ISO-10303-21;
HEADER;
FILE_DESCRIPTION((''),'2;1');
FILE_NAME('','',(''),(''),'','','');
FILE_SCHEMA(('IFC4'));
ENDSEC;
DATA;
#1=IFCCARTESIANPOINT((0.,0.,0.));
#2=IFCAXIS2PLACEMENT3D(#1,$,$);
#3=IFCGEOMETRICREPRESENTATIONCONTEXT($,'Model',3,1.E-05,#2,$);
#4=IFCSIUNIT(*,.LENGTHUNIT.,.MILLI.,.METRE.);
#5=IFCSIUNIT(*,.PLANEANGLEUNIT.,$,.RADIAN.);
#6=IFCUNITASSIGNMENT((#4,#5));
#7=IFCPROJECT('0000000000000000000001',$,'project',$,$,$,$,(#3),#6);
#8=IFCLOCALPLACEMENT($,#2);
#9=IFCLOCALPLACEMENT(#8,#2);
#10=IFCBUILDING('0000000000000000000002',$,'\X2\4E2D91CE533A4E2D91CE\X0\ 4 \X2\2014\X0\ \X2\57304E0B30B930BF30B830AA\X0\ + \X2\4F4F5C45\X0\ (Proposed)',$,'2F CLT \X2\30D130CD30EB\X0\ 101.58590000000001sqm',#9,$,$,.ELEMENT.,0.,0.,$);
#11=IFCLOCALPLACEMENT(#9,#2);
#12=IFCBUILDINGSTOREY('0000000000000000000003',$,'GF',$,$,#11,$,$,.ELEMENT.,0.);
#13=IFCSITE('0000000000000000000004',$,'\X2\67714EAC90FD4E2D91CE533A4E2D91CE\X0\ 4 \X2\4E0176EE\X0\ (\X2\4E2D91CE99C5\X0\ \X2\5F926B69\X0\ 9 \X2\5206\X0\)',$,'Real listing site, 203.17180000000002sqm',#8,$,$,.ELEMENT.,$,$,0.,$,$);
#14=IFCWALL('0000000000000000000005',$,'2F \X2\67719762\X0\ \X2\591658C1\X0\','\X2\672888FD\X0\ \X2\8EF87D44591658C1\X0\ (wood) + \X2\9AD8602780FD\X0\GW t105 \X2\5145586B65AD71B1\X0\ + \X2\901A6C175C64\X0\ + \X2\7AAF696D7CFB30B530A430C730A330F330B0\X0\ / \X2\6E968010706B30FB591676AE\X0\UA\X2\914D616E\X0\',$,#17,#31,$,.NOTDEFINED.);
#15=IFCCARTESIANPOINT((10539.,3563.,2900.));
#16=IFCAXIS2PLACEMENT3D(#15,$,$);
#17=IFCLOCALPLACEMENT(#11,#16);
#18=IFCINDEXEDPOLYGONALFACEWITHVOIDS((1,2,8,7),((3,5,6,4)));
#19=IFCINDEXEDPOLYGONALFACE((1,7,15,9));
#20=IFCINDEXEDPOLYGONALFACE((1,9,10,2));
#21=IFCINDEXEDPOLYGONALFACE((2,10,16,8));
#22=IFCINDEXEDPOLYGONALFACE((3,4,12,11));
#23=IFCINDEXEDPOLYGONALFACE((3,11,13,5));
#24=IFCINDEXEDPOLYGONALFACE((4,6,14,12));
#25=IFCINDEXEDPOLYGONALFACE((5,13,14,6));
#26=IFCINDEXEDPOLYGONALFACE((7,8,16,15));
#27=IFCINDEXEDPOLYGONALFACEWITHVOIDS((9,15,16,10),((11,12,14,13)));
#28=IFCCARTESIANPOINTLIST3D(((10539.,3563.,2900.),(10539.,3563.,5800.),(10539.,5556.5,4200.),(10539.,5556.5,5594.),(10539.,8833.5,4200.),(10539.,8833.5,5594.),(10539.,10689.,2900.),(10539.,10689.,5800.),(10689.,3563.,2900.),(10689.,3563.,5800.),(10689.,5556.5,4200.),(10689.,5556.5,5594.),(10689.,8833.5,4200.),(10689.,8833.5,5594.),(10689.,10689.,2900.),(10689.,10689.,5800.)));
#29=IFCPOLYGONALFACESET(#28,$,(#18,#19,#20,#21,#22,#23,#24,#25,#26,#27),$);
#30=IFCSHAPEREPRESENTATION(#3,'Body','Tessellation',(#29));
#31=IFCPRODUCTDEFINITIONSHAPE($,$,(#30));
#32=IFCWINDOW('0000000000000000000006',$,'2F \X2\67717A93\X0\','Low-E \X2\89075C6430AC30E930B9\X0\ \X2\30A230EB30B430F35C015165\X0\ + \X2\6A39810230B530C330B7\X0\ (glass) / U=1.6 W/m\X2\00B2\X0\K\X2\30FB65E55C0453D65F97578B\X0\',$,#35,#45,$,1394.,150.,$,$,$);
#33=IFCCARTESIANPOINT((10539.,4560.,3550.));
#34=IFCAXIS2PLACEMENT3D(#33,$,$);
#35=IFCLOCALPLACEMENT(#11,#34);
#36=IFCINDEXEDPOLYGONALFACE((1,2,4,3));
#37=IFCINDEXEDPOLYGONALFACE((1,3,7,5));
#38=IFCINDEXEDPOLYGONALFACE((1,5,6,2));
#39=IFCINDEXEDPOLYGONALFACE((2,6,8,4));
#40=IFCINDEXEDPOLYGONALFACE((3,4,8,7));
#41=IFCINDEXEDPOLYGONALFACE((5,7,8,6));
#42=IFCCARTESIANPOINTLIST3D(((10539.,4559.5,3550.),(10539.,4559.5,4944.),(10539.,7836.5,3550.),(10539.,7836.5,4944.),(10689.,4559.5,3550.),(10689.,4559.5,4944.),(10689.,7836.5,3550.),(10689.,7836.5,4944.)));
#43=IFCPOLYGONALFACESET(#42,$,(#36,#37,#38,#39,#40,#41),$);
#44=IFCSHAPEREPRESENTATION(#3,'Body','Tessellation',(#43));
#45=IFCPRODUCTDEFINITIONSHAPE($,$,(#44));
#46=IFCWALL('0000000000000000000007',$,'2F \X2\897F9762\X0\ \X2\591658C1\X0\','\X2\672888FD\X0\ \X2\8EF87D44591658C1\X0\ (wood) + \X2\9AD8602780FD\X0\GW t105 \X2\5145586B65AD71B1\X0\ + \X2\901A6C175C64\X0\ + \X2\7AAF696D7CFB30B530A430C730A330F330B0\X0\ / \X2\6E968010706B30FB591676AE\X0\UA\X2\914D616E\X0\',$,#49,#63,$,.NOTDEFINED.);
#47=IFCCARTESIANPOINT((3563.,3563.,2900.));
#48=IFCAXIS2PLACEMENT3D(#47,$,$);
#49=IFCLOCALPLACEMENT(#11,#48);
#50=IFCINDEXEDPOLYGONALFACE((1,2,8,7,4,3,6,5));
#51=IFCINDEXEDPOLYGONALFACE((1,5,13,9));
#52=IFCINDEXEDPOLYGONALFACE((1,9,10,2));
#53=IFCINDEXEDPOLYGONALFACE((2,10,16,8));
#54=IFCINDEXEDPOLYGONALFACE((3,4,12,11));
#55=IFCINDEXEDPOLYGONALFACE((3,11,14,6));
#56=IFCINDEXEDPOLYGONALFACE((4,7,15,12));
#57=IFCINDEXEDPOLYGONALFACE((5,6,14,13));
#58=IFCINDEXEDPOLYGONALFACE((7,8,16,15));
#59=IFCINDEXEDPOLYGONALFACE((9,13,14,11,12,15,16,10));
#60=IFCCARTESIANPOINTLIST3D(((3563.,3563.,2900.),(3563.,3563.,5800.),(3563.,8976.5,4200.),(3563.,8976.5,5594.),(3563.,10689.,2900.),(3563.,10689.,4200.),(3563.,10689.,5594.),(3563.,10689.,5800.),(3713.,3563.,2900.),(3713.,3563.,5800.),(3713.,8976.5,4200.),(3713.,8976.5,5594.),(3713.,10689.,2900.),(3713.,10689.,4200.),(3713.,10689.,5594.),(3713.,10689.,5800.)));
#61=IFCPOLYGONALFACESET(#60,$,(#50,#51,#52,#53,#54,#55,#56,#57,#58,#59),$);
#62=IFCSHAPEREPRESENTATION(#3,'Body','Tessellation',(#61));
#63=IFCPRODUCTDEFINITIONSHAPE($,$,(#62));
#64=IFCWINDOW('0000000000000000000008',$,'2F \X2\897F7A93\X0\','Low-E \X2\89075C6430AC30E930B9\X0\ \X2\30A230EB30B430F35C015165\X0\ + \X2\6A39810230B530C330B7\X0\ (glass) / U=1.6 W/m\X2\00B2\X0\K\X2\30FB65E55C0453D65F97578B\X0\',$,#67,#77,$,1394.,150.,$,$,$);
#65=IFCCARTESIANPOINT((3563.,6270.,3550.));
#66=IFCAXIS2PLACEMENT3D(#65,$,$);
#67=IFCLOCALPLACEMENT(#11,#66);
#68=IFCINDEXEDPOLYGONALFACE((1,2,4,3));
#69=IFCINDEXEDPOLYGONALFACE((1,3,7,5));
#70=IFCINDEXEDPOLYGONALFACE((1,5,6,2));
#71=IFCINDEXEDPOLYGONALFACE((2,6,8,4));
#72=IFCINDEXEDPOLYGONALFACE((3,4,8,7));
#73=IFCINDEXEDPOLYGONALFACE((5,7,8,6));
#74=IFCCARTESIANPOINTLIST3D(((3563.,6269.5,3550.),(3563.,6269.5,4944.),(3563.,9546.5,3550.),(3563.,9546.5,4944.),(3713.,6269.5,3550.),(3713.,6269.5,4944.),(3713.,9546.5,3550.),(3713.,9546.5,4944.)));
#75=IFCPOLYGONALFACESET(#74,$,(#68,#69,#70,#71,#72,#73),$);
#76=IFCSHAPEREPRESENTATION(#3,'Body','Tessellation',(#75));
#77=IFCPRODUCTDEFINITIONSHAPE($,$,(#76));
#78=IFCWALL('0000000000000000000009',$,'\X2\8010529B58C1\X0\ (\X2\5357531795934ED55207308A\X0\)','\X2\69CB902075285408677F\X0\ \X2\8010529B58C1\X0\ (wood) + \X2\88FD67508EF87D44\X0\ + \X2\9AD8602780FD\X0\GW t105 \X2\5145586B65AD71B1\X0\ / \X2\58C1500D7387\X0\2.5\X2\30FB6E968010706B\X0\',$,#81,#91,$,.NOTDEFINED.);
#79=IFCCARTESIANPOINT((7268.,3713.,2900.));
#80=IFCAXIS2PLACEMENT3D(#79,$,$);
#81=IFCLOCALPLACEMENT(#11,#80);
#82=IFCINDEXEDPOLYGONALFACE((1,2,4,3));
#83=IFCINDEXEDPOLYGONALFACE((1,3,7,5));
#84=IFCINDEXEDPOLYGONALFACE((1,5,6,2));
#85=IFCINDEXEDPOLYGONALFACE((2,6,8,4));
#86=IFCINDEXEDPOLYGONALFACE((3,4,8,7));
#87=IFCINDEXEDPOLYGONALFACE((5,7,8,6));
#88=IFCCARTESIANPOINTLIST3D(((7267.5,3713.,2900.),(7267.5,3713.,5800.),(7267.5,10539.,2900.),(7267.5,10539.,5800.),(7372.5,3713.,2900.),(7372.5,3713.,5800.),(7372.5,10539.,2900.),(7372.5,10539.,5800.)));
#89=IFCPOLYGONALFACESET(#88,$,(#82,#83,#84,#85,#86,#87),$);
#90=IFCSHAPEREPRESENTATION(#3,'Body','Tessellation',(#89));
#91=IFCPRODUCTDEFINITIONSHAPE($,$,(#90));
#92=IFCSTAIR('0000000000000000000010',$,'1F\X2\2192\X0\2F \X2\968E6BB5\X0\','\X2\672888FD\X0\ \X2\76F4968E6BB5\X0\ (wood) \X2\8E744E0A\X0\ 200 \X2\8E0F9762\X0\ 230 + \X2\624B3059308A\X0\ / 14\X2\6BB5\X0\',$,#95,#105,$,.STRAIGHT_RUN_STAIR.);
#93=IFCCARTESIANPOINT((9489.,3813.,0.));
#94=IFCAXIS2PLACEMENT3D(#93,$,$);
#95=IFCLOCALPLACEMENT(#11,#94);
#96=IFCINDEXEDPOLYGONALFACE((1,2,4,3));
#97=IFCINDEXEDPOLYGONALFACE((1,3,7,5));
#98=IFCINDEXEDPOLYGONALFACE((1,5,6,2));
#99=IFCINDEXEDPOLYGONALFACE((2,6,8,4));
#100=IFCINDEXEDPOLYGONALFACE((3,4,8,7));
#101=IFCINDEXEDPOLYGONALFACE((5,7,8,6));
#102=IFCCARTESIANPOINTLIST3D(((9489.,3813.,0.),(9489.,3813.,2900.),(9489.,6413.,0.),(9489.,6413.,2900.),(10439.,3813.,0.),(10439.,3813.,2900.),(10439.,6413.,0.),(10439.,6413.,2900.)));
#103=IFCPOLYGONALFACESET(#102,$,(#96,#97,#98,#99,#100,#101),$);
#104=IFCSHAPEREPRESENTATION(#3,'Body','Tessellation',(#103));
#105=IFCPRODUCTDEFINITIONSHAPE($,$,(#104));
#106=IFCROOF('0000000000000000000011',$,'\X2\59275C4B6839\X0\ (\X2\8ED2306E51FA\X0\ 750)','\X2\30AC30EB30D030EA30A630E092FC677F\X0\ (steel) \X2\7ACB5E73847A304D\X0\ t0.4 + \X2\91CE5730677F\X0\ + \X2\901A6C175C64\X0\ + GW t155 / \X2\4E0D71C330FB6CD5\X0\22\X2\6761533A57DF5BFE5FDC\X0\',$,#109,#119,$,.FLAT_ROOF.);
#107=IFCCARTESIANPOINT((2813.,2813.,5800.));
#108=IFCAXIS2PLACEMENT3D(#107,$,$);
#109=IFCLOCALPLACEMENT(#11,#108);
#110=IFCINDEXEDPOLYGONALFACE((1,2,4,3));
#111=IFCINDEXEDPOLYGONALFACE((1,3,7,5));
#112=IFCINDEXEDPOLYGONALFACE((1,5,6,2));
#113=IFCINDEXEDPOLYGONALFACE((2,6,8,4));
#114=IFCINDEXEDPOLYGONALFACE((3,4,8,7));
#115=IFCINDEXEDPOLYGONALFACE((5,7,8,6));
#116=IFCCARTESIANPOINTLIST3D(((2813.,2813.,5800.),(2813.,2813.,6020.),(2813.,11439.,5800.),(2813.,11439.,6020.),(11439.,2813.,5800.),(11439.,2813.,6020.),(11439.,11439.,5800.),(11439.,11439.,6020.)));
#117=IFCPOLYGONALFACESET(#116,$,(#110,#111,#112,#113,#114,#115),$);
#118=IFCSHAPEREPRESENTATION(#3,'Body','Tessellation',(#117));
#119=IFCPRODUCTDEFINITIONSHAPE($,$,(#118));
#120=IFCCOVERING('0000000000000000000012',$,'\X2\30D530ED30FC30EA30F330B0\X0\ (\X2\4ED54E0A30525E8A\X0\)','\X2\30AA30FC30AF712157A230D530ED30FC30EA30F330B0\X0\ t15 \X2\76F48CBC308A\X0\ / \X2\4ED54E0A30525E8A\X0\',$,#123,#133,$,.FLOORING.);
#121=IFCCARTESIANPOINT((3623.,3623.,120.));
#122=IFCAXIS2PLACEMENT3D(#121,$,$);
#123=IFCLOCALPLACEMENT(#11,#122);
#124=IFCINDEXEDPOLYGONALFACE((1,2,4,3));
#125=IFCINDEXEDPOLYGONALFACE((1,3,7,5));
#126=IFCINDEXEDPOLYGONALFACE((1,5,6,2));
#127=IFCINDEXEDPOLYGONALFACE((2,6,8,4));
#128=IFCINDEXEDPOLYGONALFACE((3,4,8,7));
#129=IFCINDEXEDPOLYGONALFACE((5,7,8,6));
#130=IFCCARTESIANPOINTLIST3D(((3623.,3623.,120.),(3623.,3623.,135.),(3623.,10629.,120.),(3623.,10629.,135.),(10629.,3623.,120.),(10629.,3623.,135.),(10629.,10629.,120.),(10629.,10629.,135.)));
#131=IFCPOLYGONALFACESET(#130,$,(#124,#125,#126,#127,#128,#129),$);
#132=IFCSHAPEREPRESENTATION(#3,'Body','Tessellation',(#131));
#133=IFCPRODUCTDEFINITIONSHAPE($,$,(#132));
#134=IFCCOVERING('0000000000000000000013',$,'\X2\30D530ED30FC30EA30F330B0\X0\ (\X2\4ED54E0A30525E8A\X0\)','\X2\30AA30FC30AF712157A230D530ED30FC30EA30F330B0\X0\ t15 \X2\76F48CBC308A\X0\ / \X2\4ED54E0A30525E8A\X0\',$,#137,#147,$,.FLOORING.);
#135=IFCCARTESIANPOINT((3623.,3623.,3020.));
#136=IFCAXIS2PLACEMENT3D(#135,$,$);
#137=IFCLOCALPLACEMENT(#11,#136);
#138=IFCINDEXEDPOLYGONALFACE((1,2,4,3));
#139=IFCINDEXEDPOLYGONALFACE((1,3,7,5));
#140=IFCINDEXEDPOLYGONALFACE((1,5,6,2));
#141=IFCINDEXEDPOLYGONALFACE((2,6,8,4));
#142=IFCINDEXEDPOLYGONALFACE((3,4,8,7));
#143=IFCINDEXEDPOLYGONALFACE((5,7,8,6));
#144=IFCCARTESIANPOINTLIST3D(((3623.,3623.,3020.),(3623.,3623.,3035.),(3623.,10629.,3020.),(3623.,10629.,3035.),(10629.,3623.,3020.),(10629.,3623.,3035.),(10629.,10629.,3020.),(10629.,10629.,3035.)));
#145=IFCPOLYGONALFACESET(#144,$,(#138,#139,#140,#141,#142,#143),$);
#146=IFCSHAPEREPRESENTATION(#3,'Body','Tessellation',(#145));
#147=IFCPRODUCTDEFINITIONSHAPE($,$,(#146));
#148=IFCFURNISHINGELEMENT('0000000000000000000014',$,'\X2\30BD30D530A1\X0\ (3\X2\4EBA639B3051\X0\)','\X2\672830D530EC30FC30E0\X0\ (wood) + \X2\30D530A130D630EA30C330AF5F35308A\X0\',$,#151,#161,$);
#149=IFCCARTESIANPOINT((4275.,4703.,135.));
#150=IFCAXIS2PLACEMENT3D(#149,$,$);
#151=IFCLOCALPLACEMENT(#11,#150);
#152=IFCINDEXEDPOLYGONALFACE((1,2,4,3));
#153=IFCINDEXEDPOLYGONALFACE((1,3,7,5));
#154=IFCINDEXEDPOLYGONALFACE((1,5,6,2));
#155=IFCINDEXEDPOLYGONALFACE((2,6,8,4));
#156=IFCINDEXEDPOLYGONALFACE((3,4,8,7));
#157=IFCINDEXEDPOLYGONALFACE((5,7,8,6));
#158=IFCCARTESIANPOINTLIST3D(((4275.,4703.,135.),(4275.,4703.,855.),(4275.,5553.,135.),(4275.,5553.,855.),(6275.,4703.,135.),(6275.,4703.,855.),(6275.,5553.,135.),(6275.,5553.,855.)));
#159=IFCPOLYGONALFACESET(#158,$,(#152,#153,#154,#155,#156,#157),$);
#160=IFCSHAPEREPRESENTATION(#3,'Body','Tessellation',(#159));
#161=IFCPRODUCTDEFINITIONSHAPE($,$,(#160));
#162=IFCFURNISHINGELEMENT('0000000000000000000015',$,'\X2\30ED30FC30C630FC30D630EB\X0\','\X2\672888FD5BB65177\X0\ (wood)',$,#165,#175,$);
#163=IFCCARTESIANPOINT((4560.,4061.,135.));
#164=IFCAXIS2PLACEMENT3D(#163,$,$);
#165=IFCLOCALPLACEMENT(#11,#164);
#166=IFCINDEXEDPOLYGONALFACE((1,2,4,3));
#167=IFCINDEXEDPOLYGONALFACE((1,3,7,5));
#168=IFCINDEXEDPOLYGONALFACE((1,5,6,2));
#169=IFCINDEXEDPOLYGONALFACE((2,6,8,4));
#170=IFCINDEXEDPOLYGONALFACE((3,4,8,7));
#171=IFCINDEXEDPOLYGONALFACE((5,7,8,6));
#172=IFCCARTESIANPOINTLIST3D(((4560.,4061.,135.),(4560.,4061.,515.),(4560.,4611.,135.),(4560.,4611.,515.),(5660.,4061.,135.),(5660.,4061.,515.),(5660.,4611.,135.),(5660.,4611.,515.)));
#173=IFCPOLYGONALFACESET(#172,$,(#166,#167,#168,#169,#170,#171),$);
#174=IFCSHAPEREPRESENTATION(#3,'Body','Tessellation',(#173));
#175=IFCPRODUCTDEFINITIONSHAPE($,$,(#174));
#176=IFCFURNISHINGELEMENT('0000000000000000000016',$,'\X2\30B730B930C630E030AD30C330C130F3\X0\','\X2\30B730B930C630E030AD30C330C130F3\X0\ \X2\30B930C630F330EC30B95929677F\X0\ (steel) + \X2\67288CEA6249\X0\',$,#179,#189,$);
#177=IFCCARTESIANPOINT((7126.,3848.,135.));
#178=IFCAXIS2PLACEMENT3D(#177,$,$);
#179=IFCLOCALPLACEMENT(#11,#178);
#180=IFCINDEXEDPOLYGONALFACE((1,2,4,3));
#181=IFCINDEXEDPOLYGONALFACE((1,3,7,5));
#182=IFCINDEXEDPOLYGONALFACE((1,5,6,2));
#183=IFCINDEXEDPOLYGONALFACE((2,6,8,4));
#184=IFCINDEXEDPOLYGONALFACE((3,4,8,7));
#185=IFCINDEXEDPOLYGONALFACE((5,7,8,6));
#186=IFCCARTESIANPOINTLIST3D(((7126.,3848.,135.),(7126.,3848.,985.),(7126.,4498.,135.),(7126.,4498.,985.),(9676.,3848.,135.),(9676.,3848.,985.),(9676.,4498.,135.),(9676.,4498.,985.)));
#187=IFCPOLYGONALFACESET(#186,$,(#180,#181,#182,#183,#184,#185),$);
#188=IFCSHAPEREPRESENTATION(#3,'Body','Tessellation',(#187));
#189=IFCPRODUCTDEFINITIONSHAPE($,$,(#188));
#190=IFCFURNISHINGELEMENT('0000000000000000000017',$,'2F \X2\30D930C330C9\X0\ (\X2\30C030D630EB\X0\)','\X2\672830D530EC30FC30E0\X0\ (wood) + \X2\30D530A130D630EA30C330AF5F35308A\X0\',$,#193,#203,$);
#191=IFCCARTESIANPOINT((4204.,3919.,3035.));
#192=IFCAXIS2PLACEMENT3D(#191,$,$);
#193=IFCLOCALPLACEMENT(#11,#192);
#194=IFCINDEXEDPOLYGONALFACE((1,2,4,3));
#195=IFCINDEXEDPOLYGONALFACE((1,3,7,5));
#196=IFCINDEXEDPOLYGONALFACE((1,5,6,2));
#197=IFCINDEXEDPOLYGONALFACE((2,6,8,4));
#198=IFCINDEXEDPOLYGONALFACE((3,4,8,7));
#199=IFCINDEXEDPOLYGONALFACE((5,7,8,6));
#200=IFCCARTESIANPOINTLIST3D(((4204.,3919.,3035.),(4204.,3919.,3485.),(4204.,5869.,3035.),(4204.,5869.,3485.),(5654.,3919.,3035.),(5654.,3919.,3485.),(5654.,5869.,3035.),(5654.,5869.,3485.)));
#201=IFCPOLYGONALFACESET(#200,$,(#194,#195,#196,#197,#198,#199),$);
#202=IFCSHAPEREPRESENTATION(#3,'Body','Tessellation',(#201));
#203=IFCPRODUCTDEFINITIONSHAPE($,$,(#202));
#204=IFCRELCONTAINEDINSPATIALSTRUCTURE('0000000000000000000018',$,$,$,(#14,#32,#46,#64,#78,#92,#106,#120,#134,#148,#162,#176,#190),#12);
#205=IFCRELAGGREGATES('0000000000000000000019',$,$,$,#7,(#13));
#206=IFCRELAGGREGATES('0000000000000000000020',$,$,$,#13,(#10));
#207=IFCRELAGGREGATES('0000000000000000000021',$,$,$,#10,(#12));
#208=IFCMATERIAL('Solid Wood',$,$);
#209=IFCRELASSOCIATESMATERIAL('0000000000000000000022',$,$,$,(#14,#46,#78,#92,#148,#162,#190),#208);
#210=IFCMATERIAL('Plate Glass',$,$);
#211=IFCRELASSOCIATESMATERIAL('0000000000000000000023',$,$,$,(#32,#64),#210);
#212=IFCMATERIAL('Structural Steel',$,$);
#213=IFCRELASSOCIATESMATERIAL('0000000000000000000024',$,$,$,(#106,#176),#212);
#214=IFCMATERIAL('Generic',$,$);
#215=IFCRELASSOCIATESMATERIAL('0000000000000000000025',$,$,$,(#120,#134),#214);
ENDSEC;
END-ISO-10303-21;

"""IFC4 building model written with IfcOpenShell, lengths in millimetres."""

from ifc_helpers import new_model, si_unit, frame, frame_2d, origin, place, context, project, spatial, rectangle, extrude, material, element, fill, save


model = new_model("IFC4")

# Units and contexts
model_context = context("Model", 3, precision=1e-05, world=origin())
ifc_project = project(units=[si_unit("LENGTHUNIT", "METRE", prefix="MILLI"), si_unit("PLANEANGLEUNIT", "RADIAN")], contexts=[model_context])

# Site, building, storey
site_placement = place(None, origin())
site = spatial("IfcSite", under=ifc_project, at=site_placement, Name="東京都中野区中野 4 丁目 (中野駅 徒歩 9 分)", ObjectType="Real listing site, 203.17180000000002sqm", CompositionType="ELEMENT", RefElevation=0.0)
building_placement = place(site_placement, origin())
building = spatial("IfcBuilding", under=site, at=building_placement, Name="中野区中野 4 — 地下スタジオ + 住居 (Proposed)", ObjectType="2F CLT パネル 101.58590000000001sqm", CompositionType="ELEMENT", ElevationOfRefHeight=0.0, ElevationOfTerrain=0.0)
storey_placement = place(building_placement, origin())
storey = spatial("IfcBuildingStorey", under=building, at=storey_placement, Name="GF", CompositionType="ELEMENT", Elevation=0.0)

# Shared definitions
ifc_material_1 = material(Name="Solid Wood")

# Shared definitions
ifc_material_2 = material(Name="Plate Glass")

# Walls, openings, windows
wall_1_placement = place(storey_placement, frame((10539.0, 3563.0, 2900.0)))
wall_1 = element("IfcWall", 1, at=wall_1_placement, inside=storey, material=ifc_material_1, Name="2F 東面 外壁", Description="木製 軸組外壁 (wood) + 高性能GW t105 充填断熱 + 通気層 + 窯業系サイディング / 準耐火・外皮UA配慮", PredefinedType="NOTDEFINED", context=model_context, shape_type="SweptSolid", body=[
    extrude(rectangle(XDim=150.0, YDim=7126.0, at=frame_2d((75.0, 3563.0))), frame((10539.0, 3563.0, 2900.0)), (0.0, 0.0, 1.0), 2900.0),
])
opening_1_placement = place(storey_placement, frame((10539.0, 4560.0, 3550.0)))
opening_1 = element("IfcOpeningElement", 2, at=opening_1_placement, cuts=wall_1, PredefinedType="NOTDEFINED", context=model_context, shape_type="SweptSolid", body=[
    extrude(rectangle(XDim=150.0, YDim=3277.0, at=frame_2d((75.0, 1638.0))), frame((10539.0, 4560.0, 3550.0)), (0.0, 0.0, 1.0), 1394.0),
])
window_1_placement = place(storey_placement, frame((10539.0, 4560.0, 3550.0)))
window_1 = element("IfcWindow", 3, at=window_1_placement, inside=storey, material=ifc_material_2, Name="2F 東窓", Description="Low-E 複層ガラス アルゴン封入 + 樹脂サッシ (glass) / U=1.6 W/m²K・日射取得型", OverallHeight=1394.0, OverallWidth=150.0, context=model_context, shape_type="SweptSolid", body=[
    extrude(rectangle(XDim=150.0, YDim=3277.0, at=frame_2d((75.0, 1638.0))), frame((10539.0, 4560.0, 3550.0)), (0.0, 0.0, 1.0), 1394.0),
])
fill(opening_1, window_1)
wall_2_placement = place(storey_placement, frame((3563.0, 3563.0, 2900.0)))
wall_2 = element("IfcWall", 4, at=wall_2_placement, inside=storey, material=ifc_material_1, Name="2F 西面 外壁", Description="木製 軸組外壁 (wood) + 高性能GW t105 充填断熱 + 通気層 + 窯業系サイディング / 準耐火・外皮UA配慮", PredefinedType="NOTDEFINED", context=model_context, shape_type="SweptSolid", body=[
    extrude(rectangle(XDim=150.0, YDim=7126.0, at=frame_2d((75.0, 3563.0))), frame((3563.0, 3563.0, 2900.0)), (0.0, 0.0, 1.0), 2900.0),
])
opening_2_placement = place(storey_placement, frame((3563.0, 6270.0, 3550.0)))
opening_2 = element("IfcOpeningElement", 5, at=opening_2_placement, cuts=wall_2, PredefinedType="NOTDEFINED", context=model_context, shape_type="SweptSolid", body=[
    extrude(rectangle(XDim=150.0, YDim=3277.0, at=frame_2d((75.0, 1638.0))), frame((3563.0, 6270.0, 3550.0)), (0.0, 0.0, 1.0), 1394.0),
])
window_2_placement = place(storey_placement, frame((3563.0, 6270.0, 3550.0)))
window_2 = element("IfcWindow", 6, at=window_2_placement, inside=storey, material=ifc_material_2, Name="2F 西窓", Description="Low-E 複層ガラス アルゴン封入 + 樹脂サッシ (glass) / U=1.6 W/m²K・日射取得型", OverallHeight=1394.0, OverallWidth=150.0, context=model_context, shape_type="SweptSolid", body=[
    extrude(rectangle(XDim=150.0, YDim=3277.0, at=frame_2d((75.0, 1638.0))), frame((3563.0, 6270.0, 3550.0)), (0.0, 0.0, 1.0), 1394.0),
])
fill(opening_2, window_2)

# Wall
wall_3_placement = place(storey_placement, frame((7268.0, 3713.0, 2900.0)))
element("IfcWall", 7, at=wall_3_placement, inside=storey, material=ifc_material_1, Name="耐力壁 (南北間仕切り)", Description="構造用合板 耐力壁 (wood) + 製材軸組 + 高性能GW t105 充填断熱 / 壁倍率2.5・準耐火", PredefinedType="NOTDEFINED", context=model_context, shape_type="SweptSolid", body=[
    extrude(rectangle(XDim=105.0, YDim=6826.0, at=frame_2d((52.0, 3413.0))), frame((7268.0, 3713.0, 2900.0)), (0.0, 0.0, 1.0), 2900.0),
])

# Stair
stair_placement = place(storey_placement, frame((9489.0, 3813.0, 0.0)))
element("IfcStair", 8, at=stair_placement, inside=storey, material=ifc_material_1, Name="1F→2F 階段", Description="木製 直階段 (wood) 蹴上 200 踏面 230 + 手すり / 14段", PredefinedType="STRAIGHT_RUN_STAIR", context=model_context, shape_type="SweptSolid", body=[
    extrude(rectangle(XDim=950.0, YDim=2600.0, at=frame_2d((475.0, 1300.0))), frame((9489.0, 3813.0, 0.0)), (0.0, 0.0, 1.0), 2900.0),
])

# Roof
ifc_material_3 = material(Name="Structural Steel")
roof_placement = place(storey_placement, frame((2813.0, 2813.0, 5800.0)))
element("IfcRoof", 9, at=roof_placement, inside=storey, material=ifc_material_3, Name="大屋根 (軒の出 750)", Description="ガルバリウム鋼板 (steel) 立平葺き t0.4 + 野地板 + 通気層 + GW t155 / 不燃・法22条区域対応", PredefinedType="FLAT_ROOF", context=model_context, shape_type="SweptSolid", body=[
    extrude(rectangle(XDim=8626.0, YDim=8626.0, at=frame_2d((4313.0, 4313.0))), frame((2813.0, 2813.0, 5800.0)), (0.0, 0.0, 1.0), 220.0),
])

# Coverings
ifc_material_4 = material(Name="Generic")
covering_1_placement = place(storey_placement, frame((3623.0, 3623.0, 120.0)))
element("IfcCovering", 10, at=covering_1_placement, inside=storey, material=ifc_material_4, Name="フローリング (仕上げ床)", Description="オーク無垢フローリング t15 直貼り / 仕上げ床", PredefinedType="FLOORING", context=model_context, shape_type="SweptSolid", body=[
    extrude(rectangle(XDim=7006.0, YDim=7006.0, at=frame_2d((3503.0, 3503.0))), frame((3623.0, 3623.0, 120.0)), (0.0, 0.0, 1.0), 15.0),
])
covering_2_placement = place(storey_placement, frame((3623.0, 3623.0, 3020.0)))
element("IfcCovering", 11, at=covering_2_placement, inside=storey, material=ifc_material_4, Name="フローリング (仕上げ床)", Description="オーク無垢フローリング t15 直貼り / 仕上げ床", PredefinedType="FLOORING", context=model_context, shape_type="SweptSolid", body=[
    extrude(rectangle(XDim=7006.0, YDim=7006.0, at=frame_2d((3503.0, 3503.0))), frame((3623.0, 3623.0, 3020.0)), (0.0, 0.0, 1.0), 15.0),
])

# Furnishing elements
furnishing_1_placement = place(storey_placement, frame((4275.0, 4703.0, 135.0)))
element("IfcFurnishingElement", 12, at=furnishing_1_placement, inside=storey, material=ifc_material_1, Name="ソファ (3人掛け)", Description="木フレーム (wood) + ファブリック張り", context=model_context, shape_type="SweptSolid", body=[
    extrude(rectangle(XDim=2000.0, YDim=850.0, at=frame_2d((1000.0, 425.0))), frame((4275.0, 4703.0, 135.0)), (0.0, 0.0, 1.0), 720.0),
])
furnishing_2_placement = place(storey_placement, frame((4560.0, 4061.0, 135.0)))
element("IfcFurnishingElement", 13, at=furnishing_2_placement, inside=storey, material=ifc_material_1, Name="ローテーブル", Description="木製家具 (wood)", context=model_context, shape_type="SweptSolid", body=[
    extrude(rectangle(XDim=1100.0, YDim=550.0, at=frame_2d((550.0, 275.0))), frame((4560.0, 4061.0, 135.0)), (0.0, 0.0, 1.0), 380.0),
])
furnishing_3_placement = place(storey_placement, frame((7126.0, 3848.0, 135.0)))
element("IfcFurnishingElement", 14, at=furnishing_3_placement, inside=storey, material=ifc_material_3, Name="システムキッチン", Description="システムキッチン ステンレス天板 (steel) + 木質扉", context=model_context, shape_type="SweptSolid", body=[
    extrude(rectangle(XDim=2550.0, YDim=650.0, at=frame_2d((1275.0, 325.0))), frame((7126.0, 3848.0, 135.0)), (0.0, 0.0, 1.0), 850.0),
])
furnishing_4_placement = place(storey_placement, frame((4204.0, 3919.0, 3035.0)))
element("IfcFurnishingElement", 15, at=furnishing_4_placement, inside=storey, material=ifc_material_1, Name="2F ベッド (ダブル)", Description="木フレーム (wood) + ファブリック張り", context=model_context, shape_type="SweptSolid", body=[
    extrude(rectangle(XDim=1450.0, YDim=1950.0, at=frame_2d((725.0, 975.0))), frame((4204.0, 3919.0, 3035.0)), (0.0, 0.0, 1.0), 450.0),
])

save(model, "model.ifc")
